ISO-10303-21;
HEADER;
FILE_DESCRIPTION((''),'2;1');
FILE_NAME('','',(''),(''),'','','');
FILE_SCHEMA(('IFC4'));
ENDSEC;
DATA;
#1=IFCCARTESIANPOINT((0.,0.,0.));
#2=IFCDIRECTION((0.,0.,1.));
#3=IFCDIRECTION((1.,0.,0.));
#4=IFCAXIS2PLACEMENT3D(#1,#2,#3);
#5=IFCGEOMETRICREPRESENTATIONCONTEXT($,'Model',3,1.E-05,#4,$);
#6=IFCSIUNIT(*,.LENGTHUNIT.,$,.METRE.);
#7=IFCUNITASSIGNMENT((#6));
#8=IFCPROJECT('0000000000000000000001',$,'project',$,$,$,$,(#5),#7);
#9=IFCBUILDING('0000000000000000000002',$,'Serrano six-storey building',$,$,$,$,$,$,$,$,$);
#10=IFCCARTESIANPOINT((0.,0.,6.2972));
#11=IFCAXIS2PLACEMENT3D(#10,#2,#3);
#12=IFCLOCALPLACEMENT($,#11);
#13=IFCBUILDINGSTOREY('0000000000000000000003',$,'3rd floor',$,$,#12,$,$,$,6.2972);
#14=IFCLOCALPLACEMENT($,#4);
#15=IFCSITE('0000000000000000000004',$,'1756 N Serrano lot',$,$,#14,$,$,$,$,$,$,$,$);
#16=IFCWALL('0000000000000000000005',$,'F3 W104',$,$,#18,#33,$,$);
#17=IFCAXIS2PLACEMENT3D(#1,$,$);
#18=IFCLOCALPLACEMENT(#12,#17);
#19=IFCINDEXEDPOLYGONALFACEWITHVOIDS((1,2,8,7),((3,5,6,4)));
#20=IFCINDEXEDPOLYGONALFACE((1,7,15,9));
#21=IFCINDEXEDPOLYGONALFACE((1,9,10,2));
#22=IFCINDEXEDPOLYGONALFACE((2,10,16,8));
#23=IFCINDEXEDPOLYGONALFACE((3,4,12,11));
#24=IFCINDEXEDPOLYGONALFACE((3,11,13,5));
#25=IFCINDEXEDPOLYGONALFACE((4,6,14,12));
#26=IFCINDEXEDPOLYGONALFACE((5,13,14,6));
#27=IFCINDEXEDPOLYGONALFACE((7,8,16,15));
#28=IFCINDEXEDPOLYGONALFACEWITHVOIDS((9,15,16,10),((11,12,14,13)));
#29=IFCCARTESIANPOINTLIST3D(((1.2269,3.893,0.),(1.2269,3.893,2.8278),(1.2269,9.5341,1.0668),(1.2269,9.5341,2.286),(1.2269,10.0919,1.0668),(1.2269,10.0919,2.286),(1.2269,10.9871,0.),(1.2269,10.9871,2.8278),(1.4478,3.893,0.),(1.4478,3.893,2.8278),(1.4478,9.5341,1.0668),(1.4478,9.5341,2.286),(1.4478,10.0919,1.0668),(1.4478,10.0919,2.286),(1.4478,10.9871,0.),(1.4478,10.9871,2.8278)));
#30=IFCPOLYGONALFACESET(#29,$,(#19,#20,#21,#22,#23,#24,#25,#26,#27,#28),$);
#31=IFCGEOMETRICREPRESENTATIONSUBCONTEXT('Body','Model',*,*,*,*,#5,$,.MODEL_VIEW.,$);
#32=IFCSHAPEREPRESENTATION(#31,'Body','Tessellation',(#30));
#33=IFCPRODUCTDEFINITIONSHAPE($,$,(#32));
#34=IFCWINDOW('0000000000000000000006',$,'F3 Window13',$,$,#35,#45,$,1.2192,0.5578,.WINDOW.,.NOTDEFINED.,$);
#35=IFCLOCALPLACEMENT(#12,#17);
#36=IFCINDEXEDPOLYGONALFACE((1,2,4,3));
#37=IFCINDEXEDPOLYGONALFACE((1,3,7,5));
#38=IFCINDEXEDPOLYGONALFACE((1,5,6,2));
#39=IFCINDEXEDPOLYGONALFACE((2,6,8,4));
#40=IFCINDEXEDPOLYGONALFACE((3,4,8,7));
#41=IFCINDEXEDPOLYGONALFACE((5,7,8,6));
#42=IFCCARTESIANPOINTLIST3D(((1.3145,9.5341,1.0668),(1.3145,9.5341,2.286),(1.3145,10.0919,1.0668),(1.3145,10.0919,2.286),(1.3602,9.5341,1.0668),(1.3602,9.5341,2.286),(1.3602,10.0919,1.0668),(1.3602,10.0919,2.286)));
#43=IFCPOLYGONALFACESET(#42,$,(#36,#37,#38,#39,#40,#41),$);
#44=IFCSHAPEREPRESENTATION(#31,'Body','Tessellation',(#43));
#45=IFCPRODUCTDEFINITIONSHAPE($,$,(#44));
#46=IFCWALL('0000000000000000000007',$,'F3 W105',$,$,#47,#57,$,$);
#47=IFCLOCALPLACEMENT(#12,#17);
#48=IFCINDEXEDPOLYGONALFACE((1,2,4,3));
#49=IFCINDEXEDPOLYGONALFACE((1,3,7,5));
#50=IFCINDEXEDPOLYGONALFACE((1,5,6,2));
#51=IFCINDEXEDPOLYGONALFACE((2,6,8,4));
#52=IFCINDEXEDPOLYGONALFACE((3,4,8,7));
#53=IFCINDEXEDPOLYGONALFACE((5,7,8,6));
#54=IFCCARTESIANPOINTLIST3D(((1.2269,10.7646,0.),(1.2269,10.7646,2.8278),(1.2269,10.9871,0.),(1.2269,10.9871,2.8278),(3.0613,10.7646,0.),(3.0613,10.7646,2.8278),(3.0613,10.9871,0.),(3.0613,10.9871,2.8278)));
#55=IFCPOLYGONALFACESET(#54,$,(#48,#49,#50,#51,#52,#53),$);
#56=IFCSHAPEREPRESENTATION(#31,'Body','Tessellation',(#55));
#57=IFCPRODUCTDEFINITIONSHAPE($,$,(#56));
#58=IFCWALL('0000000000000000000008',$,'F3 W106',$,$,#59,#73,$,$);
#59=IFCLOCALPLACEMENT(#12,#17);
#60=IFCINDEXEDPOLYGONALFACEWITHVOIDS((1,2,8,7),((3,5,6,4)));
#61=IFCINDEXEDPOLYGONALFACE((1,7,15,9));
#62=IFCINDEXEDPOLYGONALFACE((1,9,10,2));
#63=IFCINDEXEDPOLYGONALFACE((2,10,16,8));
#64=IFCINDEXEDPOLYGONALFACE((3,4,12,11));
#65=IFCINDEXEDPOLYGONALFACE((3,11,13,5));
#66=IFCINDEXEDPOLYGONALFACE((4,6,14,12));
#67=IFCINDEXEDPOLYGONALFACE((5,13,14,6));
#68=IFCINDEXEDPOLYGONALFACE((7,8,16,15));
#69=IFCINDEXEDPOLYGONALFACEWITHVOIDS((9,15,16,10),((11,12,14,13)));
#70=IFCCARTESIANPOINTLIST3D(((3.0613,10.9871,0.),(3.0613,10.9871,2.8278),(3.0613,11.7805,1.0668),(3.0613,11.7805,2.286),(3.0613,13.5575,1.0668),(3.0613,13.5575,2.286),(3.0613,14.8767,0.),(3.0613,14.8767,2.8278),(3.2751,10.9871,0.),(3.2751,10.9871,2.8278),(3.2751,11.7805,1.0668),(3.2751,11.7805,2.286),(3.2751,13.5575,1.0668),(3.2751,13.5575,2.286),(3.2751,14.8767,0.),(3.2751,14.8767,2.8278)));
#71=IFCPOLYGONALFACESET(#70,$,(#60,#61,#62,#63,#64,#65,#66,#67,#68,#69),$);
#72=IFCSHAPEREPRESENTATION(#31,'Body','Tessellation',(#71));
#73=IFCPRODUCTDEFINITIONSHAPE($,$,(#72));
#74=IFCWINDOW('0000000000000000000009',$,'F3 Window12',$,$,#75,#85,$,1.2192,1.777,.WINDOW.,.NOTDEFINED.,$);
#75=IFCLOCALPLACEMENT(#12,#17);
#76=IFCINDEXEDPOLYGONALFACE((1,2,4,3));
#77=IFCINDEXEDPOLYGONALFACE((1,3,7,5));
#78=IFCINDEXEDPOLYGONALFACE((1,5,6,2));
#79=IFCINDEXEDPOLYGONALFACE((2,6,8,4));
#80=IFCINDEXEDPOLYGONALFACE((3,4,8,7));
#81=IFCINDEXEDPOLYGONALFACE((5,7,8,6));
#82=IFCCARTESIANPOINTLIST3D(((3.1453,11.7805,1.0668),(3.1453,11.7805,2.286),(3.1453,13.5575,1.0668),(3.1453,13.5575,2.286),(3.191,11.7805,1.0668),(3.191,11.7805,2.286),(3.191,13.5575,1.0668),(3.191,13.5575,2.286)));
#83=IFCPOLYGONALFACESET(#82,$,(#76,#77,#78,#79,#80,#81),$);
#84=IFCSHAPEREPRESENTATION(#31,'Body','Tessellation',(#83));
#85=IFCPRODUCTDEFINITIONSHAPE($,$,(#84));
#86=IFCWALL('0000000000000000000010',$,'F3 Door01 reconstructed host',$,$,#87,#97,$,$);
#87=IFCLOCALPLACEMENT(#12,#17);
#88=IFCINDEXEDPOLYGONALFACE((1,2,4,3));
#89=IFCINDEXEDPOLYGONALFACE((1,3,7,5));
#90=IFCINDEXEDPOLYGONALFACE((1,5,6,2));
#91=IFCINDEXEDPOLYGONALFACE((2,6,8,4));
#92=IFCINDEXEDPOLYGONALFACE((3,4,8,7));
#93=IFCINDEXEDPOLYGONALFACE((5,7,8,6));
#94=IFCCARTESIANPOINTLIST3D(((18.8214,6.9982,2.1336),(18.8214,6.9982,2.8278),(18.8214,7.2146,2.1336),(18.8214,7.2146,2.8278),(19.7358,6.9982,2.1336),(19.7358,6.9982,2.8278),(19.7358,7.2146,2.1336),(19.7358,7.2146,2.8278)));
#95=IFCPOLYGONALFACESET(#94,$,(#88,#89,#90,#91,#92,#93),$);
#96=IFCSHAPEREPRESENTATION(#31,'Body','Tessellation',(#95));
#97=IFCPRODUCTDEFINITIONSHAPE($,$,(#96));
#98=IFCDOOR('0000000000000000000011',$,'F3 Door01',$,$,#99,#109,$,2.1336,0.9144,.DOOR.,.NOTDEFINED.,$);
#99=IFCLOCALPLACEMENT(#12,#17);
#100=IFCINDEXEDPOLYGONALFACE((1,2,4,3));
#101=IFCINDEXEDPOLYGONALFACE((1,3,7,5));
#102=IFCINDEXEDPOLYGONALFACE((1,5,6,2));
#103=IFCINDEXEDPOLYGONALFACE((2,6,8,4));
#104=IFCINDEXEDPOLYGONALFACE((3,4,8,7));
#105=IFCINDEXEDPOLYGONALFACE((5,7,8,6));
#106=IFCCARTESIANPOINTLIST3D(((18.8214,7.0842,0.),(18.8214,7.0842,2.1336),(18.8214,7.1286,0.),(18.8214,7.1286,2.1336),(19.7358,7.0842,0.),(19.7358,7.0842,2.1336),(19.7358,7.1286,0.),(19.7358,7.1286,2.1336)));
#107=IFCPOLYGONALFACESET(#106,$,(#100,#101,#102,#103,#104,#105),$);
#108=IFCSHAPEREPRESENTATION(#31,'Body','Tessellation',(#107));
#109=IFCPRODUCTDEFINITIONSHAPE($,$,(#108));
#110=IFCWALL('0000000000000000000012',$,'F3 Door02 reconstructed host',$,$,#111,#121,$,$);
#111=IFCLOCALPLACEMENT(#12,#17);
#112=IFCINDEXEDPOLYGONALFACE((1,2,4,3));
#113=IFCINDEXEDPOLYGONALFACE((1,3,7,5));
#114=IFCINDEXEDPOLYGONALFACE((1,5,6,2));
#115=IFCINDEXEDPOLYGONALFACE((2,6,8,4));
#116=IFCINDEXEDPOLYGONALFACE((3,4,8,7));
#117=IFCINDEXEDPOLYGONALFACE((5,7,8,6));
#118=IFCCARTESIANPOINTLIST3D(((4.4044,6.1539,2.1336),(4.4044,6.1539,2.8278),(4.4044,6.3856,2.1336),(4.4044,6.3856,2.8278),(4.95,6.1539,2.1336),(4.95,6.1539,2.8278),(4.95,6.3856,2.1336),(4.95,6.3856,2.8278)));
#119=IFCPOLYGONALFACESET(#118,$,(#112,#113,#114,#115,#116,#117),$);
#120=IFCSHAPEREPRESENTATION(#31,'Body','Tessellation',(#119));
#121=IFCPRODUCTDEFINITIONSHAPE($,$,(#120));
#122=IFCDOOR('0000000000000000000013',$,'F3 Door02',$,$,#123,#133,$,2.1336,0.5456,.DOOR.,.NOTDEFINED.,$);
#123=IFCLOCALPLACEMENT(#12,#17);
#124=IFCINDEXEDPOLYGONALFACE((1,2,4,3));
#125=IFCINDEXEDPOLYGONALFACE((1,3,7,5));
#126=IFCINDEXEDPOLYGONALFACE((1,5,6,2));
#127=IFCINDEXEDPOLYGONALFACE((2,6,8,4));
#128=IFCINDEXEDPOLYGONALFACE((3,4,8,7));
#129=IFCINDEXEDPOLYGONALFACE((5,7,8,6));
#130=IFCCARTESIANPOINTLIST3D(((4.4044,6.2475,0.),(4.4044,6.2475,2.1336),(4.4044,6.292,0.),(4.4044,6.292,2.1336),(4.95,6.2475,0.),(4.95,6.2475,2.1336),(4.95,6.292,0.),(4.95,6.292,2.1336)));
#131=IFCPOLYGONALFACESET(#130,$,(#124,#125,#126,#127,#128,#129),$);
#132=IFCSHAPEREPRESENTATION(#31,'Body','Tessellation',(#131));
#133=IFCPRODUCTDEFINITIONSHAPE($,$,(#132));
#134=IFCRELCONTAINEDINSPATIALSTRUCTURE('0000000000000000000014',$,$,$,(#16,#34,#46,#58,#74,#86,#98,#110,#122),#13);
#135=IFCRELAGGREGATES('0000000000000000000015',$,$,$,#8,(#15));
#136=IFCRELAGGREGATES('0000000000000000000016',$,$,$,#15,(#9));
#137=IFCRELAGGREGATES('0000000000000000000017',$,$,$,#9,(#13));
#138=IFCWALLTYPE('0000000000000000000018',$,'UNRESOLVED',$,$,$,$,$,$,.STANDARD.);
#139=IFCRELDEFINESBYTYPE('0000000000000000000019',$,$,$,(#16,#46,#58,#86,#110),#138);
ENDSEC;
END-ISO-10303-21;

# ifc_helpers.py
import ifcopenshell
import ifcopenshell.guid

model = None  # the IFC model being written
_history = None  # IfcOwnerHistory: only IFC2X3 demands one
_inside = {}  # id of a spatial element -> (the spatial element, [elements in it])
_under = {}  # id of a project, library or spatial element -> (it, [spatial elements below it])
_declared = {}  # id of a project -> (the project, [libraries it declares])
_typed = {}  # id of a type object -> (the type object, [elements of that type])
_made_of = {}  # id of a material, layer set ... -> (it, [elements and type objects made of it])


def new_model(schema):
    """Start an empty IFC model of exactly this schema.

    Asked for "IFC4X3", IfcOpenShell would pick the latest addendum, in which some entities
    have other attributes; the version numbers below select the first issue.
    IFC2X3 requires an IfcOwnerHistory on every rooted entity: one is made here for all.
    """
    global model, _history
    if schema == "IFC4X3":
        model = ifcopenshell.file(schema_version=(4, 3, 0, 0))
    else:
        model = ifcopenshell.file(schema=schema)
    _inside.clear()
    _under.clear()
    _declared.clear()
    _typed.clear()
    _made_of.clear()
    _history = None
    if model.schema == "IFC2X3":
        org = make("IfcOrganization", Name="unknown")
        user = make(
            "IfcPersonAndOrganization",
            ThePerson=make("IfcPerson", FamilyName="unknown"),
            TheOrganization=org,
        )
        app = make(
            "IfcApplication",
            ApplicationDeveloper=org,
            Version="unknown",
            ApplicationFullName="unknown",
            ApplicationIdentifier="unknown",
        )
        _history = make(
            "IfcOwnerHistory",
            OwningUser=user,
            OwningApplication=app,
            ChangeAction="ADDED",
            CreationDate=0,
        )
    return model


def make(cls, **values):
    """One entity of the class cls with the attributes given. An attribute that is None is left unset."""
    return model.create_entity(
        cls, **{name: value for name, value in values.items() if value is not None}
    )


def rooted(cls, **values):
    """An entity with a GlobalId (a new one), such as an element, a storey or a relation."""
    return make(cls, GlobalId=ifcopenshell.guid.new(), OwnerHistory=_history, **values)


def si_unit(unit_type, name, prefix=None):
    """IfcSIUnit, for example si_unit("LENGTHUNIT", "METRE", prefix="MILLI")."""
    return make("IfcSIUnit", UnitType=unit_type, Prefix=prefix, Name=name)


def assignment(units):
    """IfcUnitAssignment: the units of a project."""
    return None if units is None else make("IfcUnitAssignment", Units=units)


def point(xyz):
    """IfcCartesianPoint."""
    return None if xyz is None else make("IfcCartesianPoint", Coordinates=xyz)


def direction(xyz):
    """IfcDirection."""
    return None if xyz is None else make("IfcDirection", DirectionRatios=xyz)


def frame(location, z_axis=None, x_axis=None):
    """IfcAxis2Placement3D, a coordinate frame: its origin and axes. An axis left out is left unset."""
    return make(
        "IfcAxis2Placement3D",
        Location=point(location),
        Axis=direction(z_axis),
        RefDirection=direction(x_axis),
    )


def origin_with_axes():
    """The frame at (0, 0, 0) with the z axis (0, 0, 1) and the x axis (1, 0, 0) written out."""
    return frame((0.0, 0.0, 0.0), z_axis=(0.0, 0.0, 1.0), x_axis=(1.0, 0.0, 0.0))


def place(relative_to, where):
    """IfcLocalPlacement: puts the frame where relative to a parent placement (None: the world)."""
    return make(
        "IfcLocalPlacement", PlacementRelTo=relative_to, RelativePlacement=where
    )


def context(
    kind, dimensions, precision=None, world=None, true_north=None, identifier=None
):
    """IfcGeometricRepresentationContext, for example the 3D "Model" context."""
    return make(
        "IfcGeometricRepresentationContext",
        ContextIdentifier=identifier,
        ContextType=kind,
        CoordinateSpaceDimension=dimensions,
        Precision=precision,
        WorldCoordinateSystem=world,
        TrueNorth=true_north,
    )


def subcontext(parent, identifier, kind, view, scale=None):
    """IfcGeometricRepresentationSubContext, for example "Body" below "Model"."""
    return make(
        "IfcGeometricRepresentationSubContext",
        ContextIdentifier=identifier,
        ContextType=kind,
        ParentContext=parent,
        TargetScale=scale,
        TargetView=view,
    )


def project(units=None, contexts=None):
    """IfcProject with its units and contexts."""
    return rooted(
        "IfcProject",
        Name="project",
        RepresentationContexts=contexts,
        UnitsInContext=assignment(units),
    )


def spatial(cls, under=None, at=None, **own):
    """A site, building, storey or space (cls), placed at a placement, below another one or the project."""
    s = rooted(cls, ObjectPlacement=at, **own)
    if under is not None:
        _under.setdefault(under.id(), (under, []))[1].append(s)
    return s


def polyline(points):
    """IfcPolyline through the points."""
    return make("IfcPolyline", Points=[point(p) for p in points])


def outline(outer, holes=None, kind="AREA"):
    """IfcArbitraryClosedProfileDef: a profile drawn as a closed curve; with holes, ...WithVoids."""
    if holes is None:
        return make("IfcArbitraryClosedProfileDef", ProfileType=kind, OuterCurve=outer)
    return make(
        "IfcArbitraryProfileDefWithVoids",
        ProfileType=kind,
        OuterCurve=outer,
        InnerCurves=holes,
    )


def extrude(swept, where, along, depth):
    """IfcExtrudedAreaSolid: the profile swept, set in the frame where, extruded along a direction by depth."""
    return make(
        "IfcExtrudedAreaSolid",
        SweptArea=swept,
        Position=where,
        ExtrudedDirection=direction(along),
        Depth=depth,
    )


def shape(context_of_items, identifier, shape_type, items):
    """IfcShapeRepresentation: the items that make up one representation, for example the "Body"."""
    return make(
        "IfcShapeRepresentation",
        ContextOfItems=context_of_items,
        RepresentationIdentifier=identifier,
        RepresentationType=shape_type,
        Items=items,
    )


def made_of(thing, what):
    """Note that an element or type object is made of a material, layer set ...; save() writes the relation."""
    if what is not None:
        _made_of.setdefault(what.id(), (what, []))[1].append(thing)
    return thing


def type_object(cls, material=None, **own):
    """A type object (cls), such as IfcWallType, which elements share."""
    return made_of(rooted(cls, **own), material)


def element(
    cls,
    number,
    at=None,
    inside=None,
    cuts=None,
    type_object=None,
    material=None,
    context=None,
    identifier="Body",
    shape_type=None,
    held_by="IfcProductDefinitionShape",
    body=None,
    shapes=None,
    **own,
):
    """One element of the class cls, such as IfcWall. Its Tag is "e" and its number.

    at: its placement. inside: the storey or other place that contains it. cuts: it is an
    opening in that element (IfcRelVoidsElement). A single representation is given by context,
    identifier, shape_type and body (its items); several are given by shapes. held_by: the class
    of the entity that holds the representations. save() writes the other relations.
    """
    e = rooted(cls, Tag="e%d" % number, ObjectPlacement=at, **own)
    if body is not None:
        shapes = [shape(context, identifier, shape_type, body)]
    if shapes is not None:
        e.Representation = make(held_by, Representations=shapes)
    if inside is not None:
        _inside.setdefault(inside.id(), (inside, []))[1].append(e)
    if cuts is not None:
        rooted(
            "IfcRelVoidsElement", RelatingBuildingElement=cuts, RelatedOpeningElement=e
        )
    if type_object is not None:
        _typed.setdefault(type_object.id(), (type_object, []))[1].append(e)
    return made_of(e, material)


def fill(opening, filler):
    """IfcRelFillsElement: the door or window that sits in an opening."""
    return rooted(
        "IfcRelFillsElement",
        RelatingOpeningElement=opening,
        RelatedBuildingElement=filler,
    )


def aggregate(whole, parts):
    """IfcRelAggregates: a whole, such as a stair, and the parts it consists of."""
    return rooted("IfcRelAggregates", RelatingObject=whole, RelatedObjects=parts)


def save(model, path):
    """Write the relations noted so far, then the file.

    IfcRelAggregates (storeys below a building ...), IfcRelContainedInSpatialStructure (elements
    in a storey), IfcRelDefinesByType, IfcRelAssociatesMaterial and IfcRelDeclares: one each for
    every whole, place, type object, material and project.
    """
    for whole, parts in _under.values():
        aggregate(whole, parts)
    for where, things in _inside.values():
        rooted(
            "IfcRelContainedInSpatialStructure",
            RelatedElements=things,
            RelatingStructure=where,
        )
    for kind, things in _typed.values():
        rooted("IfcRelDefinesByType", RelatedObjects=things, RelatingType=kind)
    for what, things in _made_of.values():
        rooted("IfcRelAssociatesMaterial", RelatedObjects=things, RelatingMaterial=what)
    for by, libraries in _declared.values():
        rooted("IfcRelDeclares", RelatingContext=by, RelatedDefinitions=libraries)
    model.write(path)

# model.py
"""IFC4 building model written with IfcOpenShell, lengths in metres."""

from ifc_helpers import new_model, si_unit, frame, origin_with_axes, place, context, subcontext, project, spatial, polyline, outline, extrude, type_object, element, fill, save


model = new_model("IFC4")

# Units and contexts
model_context = context("Model", 3, precision=1e-05, world=origin_with_axes())
body_context = subcontext(model_context, "Body", "Model", "MODEL_VIEW")
ifc_project = project(units=[si_unit("LENGTHUNIT", "METRE")], contexts=[model_context])

# Site, building, storey
site_placement = place(None, origin_with_axes())
site = spatial("IfcSite", under=ifc_project, at=site_placement, Name="1756 N Serrano lot")
building = spatial("IfcBuilding", under=site, Name="Serrano six-storey building")
storey_placement = place(None, frame((0.0, 0.0, 6.2972), z_axis=(0.0, 0.0, 1.0), x_axis=(1.0, 0.0, 0.0)))
storey = spatial("IfcBuildingStorey", under=building, at=storey_placement, Name="3rd floor", Elevation=6.2972)

# Shared definitions
wall_type = type_object("IfcWallType", Name="UNRESOLVED", PredefinedType="STANDARD")

# Wall, opening, window
wall_1_placement = place(storey_placement, frame((0.0, 0.0, -6.2972), z_axis=(0.0, 0.0, 1.0), x_axis=(1.0, 0.0, 0.0)))
wall_1 = element("IfcWall", 1, at=wall_1_placement, inside=storey, type_object=wall_type, Name="F3 W104", context=body_context, shape_type="SweptSolid", body=[
    extrude(outline(polyline([(1.2269, 10.9871), (1.4478, 10.9871), (1.4478, 3.893), (1.2269, 3.893), (1.2269, 10.9871)])), frame((0.0, 0.0, 6.2972)), (0.0, 0.0, 1.0), 2.8278),
])
opening_1_placement = place(None, origin_with_axes())
opening_1 = element("IfcOpeningElement", 2, at=opening_1_placement, cuts=wall_1, PredefinedType="OPENING", context=body_context, shape_type="SweptSolid", body=[
    extrude(outline(polyline([(1.2086, 10.0919), (1.4661, 10.0919), (1.4661, 9.5341), (1.2086, 9.5341), (1.2086, 10.0919)])), frame((0.0, 0.0, 7.364)), (0.0, 0.0, 1.0), 1.2192),
])
window_1_placement = place(storey_placement, frame((0.0, 0.0, -6.2972), z_axis=(0.0, 0.0, 1.0), x_axis=(1.0, 0.0, 0.0)))
window_1 = element("IfcWindow", 3, at=window_1_placement, inside=storey, Name="F3 Window13", OverallHeight=1.2192, OverallWidth=0.5578, PartitioningType="NOTDEFINED", PredefinedType="WINDOW", context=body_context, shape_type="SweptSolid", body=[
    extrude(outline(polyline([(1.3145, 10.0919), (1.3602, 10.0919), (1.3602, 9.5341), (1.3145, 9.5341), (1.3145, 10.0919)])), frame((0.0, 0.0, 7.364)), (0.0, 0.0, 1.0), 1.2192),
])
fill(opening_1, window_1)

# Wall
wall_2_placement = place(storey_placement, frame((0.0, 0.0, -6.2972), z_axis=(0.0, 0.0, 1.0), x_axis=(1.0, 0.0, 0.0)))
element("IfcWall", 4, at=wall_2_placement, inside=storey, type_object=wall_type, Name="F3 W105", context=body_context, shape_type="SweptSolid", body=[
    extrude(outline(polyline([(3.0613, 10.9871), (3.0613, 10.7646), (1.2269, 10.7646), (1.2269, 10.9871), (3.0613, 10.9871)])), frame((0.0, 0.0, 6.2972)), (0.0, 0.0, 1.0), 2.8278),
])

# Wall, opening, window
wall_3_placement = place(storey_placement, frame((0.0, 0.0, -6.2972), z_axis=(0.0, 0.0, 1.0), x_axis=(1.0, 0.0, 0.0)))
wall_3 = element("IfcWall", 5, at=wall_3_placement, inside=storey, type_object=wall_type, Name="F3 W106", context=body_context, shape_type="SweptSolid", body=[
    extrude(outline(polyline([(3.0613, 14.8767), (3.2751, 14.8767), (3.2751, 10.9871), (3.0613, 10.9871), (3.0613, 14.8767)])), frame((0.0, 0.0, 6.2972)), (0.0, 0.0, 1.0), 2.8278),
])
opening_2_placement = place(None, origin_with_axes())
opening_2 = element("IfcOpeningElement", 6, at=opening_2_placement, cuts=wall_3, PredefinedType="OPENING", context=body_context, shape_type="SweptSolid", body=[
    extrude(outline(polyline([(3.043, 13.5575), (3.2934, 13.5575), (3.2934, 11.7805), (3.043, 11.7805), (3.043, 13.5575)])), frame((0.0, 0.0, 7.364)), (0.0, 0.0, 1.0), 1.2192),
])
window_2_placement = place(storey_placement, frame((0.0, 0.0, -6.2972), z_axis=(0.0, 0.0, 1.0), x_axis=(1.0, 0.0, 0.0)))
window_2 = element("IfcWindow", 7, at=window_2_placement, inside=storey, Name="F3 Window12", OverallHeight=1.2192, OverallWidth=1.777, PartitioningType="NOTDEFINED", PredefinedType="WINDOW", context=body_context, shape_type="SweptSolid", body=[
    extrude(outline(polyline([(3.1453, 13.5575), (3.191, 13.5575), (3.191, 11.7805), (3.1453, 11.7805), (3.1453, 13.5575)])), frame((0.0, 0.0, 7.364)), (0.0, 0.0, 1.0), 1.2192),
])
fill(opening_2, window_2)

# Walls, openings, doors
wall_4_placement = place(storey_placement, frame((0.0, 0.0, -6.2972), z_axis=(0.0, 0.0, 1.0), x_axis=(1.0, 0.0, 0.0)))
wall_4 = element("IfcWall", 8, at=wall_4_placement, inside=storey, type_object=wall_type, Name="F3 Door01 reconstructed host", context=body_context, shape_type="SweptSolid", body=[
    extrude(outline(polyline([(18.8214, 6.9982), (18.8214, 7.2146), (19.7358, 7.2146), (19.7358, 6.9982), (18.8214, 6.9982)])), frame((0.0, 0.0, 6.2972)), (0.0, 0.0, 1.0), 2.8278),
])
opening_3_placement = place(None, origin_with_axes())
opening_3 = element("IfcOpeningElement", 9, at=opening_3_placement, cuts=wall_4, PredefinedType="OPENING", context=body_context, shape_type="SweptSolid", body=[
    extrude(outline(polyline([(18.8214, 6.9799), (18.8214, 7.2329), (19.7358, 7.2329), (19.7358, 6.9799), (18.8214, 6.9799)])), frame((0.0, 0.0, 6.2972)), (0.0, 0.0, 1.0), 2.1336),
])
door_1_placement = place(storey_placement, frame((0.0, 0.0, -6.2972), z_axis=(0.0, 0.0, 1.0), x_axis=(1.0, 0.0, 0.0)))
door_1 = element("IfcDoor", 10, at=door_1_placement, inside=storey, Name="F3 Door01", OperationType="NOTDEFINED", OverallHeight=2.1336, OverallWidth=0.9144, PredefinedType="DOOR", context=body_context, shape_type="SweptSolid", body=[
    extrude(outline(polyline([(18.8214, 7.0842), (18.8214, 7.1286), (19.7358, 7.1286), (19.7358, 7.0842), (18.8214, 7.0842)])), frame((0.0, 0.0, 6.2972)), (0.0, 0.0, 1.0), 2.1336),
])
fill(opening_3, door_1)
wall_5_placement = place(storey_placement, frame((0.0, 0.0, -6.2972), z_axis=(0.0, 0.0, 1.0), x_axis=(1.0, 0.0, 0.0)))
wall_5 = element("IfcWall", 11, at=wall_5_placement, inside=storey, type_object=wall_type, Name="F3 Door02 reconstructed host", context=body_context, shape_type="SweptSolid", body=[
    extrude(outline(polyline([(4.95, 6.3856), (4.95, 6.1539), (4.4044, 6.1539), (4.4044, 6.3856), (4.95, 6.3856)])), frame((0.0, 0.0, 6.2972)), (0.0, 0.0, 1.0), 2.8278),
])
opening_4_placement = place(None, origin_with_axes())
opening_4 = element("IfcOpeningElement", 12, at=opening_4_placement, cuts=wall_5, PredefinedType="OPENING", context=body_context, shape_type="SweptSolid", body=[
    extrude(outline(polyline([(4.95, 6.4038), (4.95, 6.1356), (4.4044, 6.1356), (4.4044, 6.4038), (4.95, 6.4038)])), frame((0.0, 0.0, 6.2972)), (0.0, 0.0, 1.0), 2.1336),
])
door_2_placement = place(storey_placement, frame((0.0, 0.0, -6.2972), z_axis=(0.0, 0.0, 1.0), x_axis=(1.0, 0.0, 0.0)))
door_2 = element("IfcDoor", 13, at=door_2_placement, inside=storey, Name="F3 Door02", OperationType="NOTDEFINED", OverallHeight=2.1336, OverallWidth=0.5456, PredefinedType="DOOR", context=body_context, shape_type="SweptSolid", body=[
    extrude(outline(polyline([(4.95, 6.292), (4.95, 6.2475), (4.4044, 6.2475), (4.4044, 6.292), (4.95, 6.292)])), frame((0.0, 0.0, 6.2972)), (0.0, 0.0, 1.0), 2.1336),
])
fill(opening_4, door_2)

save(model, "model.ifc")
